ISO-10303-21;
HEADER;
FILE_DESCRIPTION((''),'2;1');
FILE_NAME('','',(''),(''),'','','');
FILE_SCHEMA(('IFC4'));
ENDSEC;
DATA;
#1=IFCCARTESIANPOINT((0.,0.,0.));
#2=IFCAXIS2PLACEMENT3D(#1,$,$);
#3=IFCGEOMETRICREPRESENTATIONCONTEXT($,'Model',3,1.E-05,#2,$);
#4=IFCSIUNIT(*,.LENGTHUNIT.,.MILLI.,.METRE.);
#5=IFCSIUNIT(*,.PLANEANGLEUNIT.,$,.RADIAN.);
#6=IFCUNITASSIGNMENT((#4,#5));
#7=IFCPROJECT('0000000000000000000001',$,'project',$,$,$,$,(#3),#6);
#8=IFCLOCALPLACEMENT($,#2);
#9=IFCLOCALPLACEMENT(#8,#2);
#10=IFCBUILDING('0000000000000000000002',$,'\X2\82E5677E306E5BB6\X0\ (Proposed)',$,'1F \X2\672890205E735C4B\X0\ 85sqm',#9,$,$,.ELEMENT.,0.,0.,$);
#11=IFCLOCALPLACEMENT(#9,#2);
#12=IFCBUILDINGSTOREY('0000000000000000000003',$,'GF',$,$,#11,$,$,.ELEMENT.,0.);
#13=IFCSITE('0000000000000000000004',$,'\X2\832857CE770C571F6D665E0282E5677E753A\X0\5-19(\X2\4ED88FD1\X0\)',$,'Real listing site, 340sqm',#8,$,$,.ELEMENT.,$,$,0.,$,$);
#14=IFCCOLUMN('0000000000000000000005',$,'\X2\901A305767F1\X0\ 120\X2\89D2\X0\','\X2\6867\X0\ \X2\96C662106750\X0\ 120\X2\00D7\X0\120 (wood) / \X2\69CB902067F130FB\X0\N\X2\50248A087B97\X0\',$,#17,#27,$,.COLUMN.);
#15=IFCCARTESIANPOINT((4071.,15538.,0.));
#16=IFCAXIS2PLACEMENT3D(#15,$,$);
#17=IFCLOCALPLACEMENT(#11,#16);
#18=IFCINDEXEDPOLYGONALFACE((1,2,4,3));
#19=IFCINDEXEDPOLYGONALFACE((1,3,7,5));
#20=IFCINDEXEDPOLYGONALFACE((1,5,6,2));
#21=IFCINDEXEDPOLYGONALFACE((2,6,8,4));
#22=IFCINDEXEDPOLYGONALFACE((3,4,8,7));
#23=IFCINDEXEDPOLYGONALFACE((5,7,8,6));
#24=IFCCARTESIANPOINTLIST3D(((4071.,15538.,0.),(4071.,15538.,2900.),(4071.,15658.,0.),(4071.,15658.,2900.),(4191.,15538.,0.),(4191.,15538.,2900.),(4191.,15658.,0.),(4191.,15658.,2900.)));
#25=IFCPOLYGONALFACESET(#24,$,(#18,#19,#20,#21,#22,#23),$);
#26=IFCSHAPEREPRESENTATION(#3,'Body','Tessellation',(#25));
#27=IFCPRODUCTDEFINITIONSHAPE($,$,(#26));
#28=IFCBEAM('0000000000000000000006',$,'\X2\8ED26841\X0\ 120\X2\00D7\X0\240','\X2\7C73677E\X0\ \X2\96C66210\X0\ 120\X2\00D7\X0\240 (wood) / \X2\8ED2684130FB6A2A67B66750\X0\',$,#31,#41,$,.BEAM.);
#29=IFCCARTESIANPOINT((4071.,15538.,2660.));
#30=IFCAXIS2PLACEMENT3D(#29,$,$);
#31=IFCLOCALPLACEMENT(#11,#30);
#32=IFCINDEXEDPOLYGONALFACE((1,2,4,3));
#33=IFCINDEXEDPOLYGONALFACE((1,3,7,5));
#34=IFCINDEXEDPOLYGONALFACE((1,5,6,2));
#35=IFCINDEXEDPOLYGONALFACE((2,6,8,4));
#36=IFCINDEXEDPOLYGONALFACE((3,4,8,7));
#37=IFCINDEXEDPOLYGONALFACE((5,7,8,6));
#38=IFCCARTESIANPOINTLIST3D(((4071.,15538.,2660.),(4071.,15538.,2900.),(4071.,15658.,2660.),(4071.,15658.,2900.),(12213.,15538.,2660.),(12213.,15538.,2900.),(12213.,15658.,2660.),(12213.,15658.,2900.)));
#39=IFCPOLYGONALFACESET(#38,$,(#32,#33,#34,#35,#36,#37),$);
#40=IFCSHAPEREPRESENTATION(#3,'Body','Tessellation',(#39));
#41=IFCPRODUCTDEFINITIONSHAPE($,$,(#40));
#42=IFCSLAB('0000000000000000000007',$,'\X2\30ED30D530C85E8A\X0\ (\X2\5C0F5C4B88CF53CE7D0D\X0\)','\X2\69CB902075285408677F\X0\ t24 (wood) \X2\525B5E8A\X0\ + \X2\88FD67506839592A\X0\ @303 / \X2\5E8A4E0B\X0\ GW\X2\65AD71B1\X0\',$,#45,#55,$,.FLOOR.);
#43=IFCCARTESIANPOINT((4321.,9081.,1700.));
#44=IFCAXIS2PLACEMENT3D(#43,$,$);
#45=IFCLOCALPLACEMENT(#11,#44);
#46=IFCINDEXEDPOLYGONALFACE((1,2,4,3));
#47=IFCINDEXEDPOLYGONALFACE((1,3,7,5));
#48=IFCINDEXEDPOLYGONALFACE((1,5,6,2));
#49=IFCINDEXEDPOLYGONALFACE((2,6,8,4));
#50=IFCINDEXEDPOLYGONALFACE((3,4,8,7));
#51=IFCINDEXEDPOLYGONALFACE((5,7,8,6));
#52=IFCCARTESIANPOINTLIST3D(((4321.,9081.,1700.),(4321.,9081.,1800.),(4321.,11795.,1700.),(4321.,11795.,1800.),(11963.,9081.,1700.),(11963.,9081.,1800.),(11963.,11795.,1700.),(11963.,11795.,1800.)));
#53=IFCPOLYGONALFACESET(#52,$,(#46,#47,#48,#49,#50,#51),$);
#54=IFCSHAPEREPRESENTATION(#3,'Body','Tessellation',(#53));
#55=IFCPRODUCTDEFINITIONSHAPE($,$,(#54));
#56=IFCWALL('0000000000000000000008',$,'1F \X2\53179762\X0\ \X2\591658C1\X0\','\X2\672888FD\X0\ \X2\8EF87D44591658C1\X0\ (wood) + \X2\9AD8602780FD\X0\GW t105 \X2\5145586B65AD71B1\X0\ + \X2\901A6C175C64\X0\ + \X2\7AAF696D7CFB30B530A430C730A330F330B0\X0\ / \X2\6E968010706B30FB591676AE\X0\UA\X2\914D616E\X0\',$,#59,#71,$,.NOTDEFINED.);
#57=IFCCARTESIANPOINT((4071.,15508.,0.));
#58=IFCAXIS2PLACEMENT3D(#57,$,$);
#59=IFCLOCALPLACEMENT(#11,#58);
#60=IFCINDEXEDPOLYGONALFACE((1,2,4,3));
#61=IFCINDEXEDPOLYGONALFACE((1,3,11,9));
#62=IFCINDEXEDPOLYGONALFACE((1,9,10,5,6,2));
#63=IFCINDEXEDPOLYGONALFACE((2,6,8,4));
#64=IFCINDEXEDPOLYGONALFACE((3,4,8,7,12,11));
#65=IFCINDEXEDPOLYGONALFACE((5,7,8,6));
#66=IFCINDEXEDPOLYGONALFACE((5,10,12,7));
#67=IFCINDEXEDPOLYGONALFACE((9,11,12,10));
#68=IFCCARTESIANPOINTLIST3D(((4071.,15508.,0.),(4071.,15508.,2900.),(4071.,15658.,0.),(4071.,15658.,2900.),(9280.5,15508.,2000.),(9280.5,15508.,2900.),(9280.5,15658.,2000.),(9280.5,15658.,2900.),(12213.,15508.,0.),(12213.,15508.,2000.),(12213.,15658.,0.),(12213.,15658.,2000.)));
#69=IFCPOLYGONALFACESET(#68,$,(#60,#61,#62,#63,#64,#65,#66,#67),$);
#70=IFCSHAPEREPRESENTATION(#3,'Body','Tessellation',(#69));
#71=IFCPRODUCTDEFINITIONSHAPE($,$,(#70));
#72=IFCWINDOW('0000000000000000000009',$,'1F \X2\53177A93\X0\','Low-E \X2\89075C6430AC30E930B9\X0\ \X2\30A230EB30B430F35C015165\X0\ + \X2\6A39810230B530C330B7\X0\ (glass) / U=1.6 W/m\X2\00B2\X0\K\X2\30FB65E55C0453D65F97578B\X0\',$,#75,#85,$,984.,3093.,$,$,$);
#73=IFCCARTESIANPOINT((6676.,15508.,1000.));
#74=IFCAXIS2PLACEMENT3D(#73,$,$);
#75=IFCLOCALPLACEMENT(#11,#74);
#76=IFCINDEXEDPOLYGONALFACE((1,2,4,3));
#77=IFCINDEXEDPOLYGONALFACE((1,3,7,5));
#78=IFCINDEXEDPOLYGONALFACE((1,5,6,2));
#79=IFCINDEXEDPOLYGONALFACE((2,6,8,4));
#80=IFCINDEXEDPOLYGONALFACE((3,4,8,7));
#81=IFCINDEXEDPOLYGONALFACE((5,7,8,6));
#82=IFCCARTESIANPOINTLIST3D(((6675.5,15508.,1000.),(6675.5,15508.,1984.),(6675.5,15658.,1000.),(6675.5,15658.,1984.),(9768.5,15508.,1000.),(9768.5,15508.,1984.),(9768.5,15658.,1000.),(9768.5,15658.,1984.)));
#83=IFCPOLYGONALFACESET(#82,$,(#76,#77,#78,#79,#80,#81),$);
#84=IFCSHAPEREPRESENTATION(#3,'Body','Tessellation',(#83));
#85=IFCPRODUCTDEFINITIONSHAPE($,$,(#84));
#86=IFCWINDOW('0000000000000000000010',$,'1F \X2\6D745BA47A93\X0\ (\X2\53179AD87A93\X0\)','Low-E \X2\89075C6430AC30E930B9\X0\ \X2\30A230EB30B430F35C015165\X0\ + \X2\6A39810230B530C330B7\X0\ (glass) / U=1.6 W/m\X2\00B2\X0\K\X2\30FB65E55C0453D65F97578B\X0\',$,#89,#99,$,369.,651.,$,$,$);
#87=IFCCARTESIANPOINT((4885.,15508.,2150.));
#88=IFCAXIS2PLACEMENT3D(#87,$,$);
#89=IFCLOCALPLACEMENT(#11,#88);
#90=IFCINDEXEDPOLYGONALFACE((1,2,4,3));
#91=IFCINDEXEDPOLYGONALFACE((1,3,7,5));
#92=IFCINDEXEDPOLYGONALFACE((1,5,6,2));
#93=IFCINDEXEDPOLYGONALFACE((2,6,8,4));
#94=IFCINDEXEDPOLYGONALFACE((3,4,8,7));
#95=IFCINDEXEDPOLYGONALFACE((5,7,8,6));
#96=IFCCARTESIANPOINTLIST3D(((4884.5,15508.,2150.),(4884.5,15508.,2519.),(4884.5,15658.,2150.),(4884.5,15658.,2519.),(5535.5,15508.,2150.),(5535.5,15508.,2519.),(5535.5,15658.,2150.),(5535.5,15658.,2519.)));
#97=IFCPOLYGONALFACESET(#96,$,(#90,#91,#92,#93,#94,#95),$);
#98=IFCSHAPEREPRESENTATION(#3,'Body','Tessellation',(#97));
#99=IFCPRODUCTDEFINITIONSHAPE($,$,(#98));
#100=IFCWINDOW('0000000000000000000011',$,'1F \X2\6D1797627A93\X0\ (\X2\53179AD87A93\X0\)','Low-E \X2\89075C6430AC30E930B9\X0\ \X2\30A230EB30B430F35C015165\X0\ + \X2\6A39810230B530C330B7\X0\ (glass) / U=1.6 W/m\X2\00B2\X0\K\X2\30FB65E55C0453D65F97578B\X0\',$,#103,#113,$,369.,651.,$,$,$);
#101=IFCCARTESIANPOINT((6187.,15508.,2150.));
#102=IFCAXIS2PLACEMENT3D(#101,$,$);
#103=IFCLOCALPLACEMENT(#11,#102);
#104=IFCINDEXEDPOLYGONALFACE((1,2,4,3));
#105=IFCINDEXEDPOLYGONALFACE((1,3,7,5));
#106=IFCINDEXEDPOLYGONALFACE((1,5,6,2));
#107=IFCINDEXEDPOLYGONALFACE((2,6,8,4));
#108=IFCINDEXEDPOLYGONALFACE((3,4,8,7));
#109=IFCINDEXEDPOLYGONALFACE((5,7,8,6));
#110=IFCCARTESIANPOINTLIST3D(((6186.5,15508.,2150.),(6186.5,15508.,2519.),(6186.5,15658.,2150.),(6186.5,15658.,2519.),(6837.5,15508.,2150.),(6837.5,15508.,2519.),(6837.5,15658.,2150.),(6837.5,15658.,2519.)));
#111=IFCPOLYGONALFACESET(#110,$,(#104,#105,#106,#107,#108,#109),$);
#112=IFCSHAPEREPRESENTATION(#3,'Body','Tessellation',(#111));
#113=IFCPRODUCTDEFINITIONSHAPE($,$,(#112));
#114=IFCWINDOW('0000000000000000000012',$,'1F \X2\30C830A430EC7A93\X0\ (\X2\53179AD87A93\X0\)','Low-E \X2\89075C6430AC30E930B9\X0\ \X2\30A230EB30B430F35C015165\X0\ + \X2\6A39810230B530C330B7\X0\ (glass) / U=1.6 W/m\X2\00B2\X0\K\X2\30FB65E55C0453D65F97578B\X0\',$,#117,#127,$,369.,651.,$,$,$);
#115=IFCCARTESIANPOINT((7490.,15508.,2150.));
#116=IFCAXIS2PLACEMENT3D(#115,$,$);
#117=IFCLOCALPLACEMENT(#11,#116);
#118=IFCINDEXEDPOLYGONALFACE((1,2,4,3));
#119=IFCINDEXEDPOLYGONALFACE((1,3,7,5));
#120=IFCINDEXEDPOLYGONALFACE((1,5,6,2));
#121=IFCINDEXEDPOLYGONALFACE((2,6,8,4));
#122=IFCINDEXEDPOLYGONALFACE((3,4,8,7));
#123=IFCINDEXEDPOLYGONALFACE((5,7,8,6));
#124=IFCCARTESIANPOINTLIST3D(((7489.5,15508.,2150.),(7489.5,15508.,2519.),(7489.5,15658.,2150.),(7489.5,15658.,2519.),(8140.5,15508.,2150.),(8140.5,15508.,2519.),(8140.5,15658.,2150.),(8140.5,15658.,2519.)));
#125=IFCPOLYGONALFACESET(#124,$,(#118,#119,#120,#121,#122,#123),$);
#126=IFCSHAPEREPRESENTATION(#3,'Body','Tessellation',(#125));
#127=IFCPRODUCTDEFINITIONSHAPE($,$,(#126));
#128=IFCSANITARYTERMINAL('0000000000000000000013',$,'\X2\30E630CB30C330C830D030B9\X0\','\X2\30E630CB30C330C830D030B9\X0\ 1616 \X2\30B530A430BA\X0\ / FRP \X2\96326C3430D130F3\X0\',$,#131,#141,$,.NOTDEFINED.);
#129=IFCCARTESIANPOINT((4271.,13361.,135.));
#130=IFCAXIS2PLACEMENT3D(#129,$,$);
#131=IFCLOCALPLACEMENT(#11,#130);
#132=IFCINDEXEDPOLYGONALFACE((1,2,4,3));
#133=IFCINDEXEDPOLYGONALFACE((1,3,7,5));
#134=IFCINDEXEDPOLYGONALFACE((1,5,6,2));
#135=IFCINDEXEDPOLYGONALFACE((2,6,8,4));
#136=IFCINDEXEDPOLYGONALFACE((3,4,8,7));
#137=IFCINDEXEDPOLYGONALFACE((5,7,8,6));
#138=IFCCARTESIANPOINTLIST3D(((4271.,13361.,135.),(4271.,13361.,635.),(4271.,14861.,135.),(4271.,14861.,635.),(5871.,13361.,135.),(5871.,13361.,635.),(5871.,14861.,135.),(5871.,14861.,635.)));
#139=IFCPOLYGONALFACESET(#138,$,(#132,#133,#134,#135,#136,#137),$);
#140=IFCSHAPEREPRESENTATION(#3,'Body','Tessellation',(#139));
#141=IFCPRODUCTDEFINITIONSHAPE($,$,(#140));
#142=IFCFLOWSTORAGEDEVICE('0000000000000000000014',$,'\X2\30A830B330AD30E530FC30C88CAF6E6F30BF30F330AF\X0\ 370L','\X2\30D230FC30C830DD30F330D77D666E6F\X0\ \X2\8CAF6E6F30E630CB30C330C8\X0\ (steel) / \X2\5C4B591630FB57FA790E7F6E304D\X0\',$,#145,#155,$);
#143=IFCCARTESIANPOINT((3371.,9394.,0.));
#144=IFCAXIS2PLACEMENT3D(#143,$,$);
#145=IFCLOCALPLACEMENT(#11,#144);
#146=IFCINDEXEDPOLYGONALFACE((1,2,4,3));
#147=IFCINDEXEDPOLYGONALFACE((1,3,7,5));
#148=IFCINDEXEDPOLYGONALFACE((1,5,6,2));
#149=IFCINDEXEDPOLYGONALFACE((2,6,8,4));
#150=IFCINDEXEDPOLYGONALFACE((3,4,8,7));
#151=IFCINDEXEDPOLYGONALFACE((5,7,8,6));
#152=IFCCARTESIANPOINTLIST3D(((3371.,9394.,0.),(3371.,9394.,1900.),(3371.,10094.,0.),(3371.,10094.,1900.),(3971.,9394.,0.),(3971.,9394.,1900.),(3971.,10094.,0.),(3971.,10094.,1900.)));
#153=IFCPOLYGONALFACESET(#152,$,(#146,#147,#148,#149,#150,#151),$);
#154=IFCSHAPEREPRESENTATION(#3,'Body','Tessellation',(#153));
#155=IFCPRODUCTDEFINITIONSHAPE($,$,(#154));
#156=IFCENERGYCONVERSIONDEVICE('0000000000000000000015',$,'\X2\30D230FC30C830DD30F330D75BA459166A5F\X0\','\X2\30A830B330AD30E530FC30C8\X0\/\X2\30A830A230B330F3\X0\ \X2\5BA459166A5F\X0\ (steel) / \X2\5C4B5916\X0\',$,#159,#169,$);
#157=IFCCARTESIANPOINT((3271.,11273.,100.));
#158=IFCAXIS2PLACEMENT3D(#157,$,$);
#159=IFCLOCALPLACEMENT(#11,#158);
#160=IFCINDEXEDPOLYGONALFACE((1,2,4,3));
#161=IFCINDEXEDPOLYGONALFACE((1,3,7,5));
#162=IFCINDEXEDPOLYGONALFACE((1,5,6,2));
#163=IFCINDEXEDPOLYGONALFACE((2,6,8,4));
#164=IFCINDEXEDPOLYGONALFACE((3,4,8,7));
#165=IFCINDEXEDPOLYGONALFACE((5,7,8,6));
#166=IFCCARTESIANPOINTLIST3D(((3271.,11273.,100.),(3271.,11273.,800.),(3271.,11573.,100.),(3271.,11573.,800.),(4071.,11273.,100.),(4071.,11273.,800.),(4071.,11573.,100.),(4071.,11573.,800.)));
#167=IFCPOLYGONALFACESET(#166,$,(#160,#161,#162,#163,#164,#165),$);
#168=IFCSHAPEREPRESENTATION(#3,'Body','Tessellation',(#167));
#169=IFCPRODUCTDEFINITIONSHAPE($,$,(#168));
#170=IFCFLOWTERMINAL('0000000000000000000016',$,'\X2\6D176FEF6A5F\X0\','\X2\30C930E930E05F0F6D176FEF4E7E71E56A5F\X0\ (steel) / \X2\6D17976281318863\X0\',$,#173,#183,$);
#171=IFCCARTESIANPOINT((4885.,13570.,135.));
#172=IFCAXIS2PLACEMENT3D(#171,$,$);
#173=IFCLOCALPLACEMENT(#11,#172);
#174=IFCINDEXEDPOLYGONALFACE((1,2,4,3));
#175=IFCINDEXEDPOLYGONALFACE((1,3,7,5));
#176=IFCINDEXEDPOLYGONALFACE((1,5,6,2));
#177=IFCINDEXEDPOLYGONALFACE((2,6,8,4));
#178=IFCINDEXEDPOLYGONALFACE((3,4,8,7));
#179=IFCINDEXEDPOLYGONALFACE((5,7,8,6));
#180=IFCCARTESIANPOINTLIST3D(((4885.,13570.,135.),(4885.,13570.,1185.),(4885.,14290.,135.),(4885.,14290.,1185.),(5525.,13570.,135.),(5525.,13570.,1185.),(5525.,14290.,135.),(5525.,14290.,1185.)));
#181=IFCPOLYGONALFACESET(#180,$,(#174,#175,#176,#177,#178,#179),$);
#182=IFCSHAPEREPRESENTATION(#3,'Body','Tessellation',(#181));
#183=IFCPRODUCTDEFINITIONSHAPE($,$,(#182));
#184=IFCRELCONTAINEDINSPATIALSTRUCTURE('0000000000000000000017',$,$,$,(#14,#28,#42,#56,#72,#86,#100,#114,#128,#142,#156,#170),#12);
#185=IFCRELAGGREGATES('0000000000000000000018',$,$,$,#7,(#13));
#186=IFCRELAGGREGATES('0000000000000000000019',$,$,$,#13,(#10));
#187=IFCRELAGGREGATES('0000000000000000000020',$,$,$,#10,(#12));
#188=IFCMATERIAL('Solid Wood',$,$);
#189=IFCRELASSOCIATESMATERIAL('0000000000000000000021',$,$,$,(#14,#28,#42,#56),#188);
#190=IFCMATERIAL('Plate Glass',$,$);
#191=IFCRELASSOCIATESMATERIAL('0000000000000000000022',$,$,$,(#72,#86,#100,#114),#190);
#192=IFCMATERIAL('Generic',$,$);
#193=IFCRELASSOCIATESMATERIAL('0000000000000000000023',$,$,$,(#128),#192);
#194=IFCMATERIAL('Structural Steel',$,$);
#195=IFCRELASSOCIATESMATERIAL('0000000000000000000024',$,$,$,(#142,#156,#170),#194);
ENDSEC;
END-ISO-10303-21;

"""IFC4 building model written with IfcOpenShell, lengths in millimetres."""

from ifc_helpers import new_model, si_unit, frame, frame_2d, origin, place, context, project, spatial, rectangle, extrude, material, element, fill, save


model = new_model("IFC4")

# Units and contexts
model_context = context("Model", 3, precision=1e-05, world=origin())
ifc_project = project(units=[si_unit("LENGTHUNIT", "METRE", prefix="MILLI"), si_unit("PLANEANGLEUNIT", "RADIAN")], contexts=[model_context])

# Site, building, storey
site_placement = place(None, origin())
site = spatial("IfcSite", under=ifc_project, at=site_placement, Name="茨城県土浦市若松町5-19(付近)", ObjectType="Real listing site, 340sqm", CompositionType="ELEMENT", RefElevation=0.0)
building_placement = place(site_placement, origin())
building = spatial("IfcBuilding", under=site, at=building_placement, Name="若松の家 (Proposed)", ObjectType="1F 木造平屋 85sqm", CompositionType="ELEMENT", ElevationOfRefHeight=0.0, ElevationOfTerrain=0.0)
storey_placement = place(building_placement, origin())
storey = spatial("IfcBuildingStorey", under=building, at=storey_placement, Name="GF", CompositionType="ELEMENT", Elevation=0.0)

# Column
ifc_material_1 = material(Name="Solid Wood")
column_1_placement = place(storey_placement, frame((4071.0, 15538.0, 0.0)))
element("IfcColumn", 1, at=column_1_placement, inside=storey, material=ifc_material_1, Name="通し柱 120角", Description="桧 集成材 120×120 (wood) / 構造柱・N値計算", PredefinedType="COLUMN", context=model_context, shape_type="SweptSolid", body=[
    extrude(rectangle(XDim=120.0, YDim=120.0, at=frame_2d((60.0, 60.0))), frame((4071.0, 15538.0, 0.0)), (0.0, 0.0, 1.0), 2900.0),
])

# Beam
beam_1_placement = place(storey_placement, frame((4071.0, 15538.0, 2660.0)))
element("IfcBeam", 2, at=beam_1_placement, inside=storey, material=ifc_material_1, Name="軒桁 120×240", Description="米松 集成 120×240 (wood) / 軒桁・横架材", PredefinedType="BEAM", context=model_context, shape_type="SweptSolid", body=[
    extrude(rectangle(XDim=8142.0, YDim=120.0, at=frame_2d((4071.0, 60.0))), frame((4071.0, 15538.0, 2660.0)), (0.0, 0.0, 1.0), 240.0),
])

# Slab
slab_placement = place(storey_placement, frame((4321.0, 9081.0, 1700.0)))
element("IfcSlab", 3, at=slab_placement, inside=storey, material=ifc_material_1, Name="ロフト床 (小屋裏収納)", Description="構造用合板 t24 (wood) 剛床 + 製材根太 @303 / 床下 GW断熱", PredefinedType="FLOOR", context=model_context, shape_type="SweptSolid", body=[
    extrude(rectangle(XDim=7642.0, YDim=2714.0, at=frame_2d((3821.0, 1357.0))), frame((4321.0, 9081.0, 1700.0)), (0.0, 0.0, 1.0), 100.0),
])

# Wall, openings, windows
wall_1_placement = place(storey_placement, frame((4071.0, 15508.0, 0.0)))
wall_1 = element("IfcWall", 4, at=wall_1_placement, inside=storey, material=ifc_material_1, Name="1F 北面 外壁", Description="木製 軸組外壁 (wood) + 高性能GW t105 充填断熱 + 通気層 + 窯業系サイディング / 準耐火・外皮UA配慮", PredefinedType="NOTDEFINED", context=model_context, shape_type="SweptSolid", body=[
    extrude(rectangle(XDim=8142.0, YDim=150.0, at=frame_2d((4071.0, 75.0))), frame((4071.0, 15508.0, 0.0)), (0.0, 0.0, 1.0), 2900.0),
])
opening_1_placement = place(storey_placement, frame((6676.0, 15508.0, 1000.0)))
opening_1 = element("IfcOpeningElement", 5, at=opening_1_placement, cuts=wall_1, PredefinedType="NOTDEFINED", context=model_context, shape_type="SweptSolid", body=[
    extrude(rectangle(XDim=3093.0, YDim=150.0, at=frame_2d((1546.0, 75.0))), frame((6676.0, 15508.0, 1000.0)), (0.0, 0.0, 1.0), 984.0),
])
opening_2_placement = place(storey_placement, frame((4885.0, 15508.0, 2150.0)))
opening_2 = element("IfcOpeningElement", 6, at=opening_2_placement, cuts=wall_1, PredefinedType="NOTDEFINED", context=model_context, shape_type="SweptSolid", body=[
    extrude(rectangle(XDim=651.0, YDim=150.0, at=frame_2d((325.0, 75.0))), frame((4885.0, 15508.0, 2150.0)), (0.0, 0.0, 1.0), 369.0),
])
opening_3_placement = place(storey_placement, frame((6187.0, 15508.0, 2150.0)))
opening_3 = element("IfcOpeningElement", 7, at=opening_3_placement, cuts=wall_1, PredefinedType="NOTDEFINED", context=model_context, shape_type="SweptSolid", body=[
    extrude(rectangle(XDim=651.0, YDim=150.0, at=frame_2d((325.0, 75.0))), frame((6187.0, 15508.0, 2150.0)), (0.0, 0.0, 1.0), 369.0),
])
opening_4_placement = place(storey_placement, frame((7490.0, 15508.0, 2150.0)))
opening_4 = element("IfcOpeningElement", 8, at=opening_4_placement, cuts=wall_1, PredefinedType="NOTDEFINED", context=model_context, shape_type="SweptSolid", body=[
    extrude(rectangle(XDim=651.0, YDim=150.0, at=frame_2d((325.0, 75.0))), frame((7490.0, 15508.0, 2150.0)), (0.0, 0.0, 1.0), 369.0),
])
ifc_material_2 = material(Name="Plate Glass")
window_1_placement = place(storey_placement, frame((6676.0, 15508.0, 1000.0)))
window_1 = element("IfcWindow", 9, at=window_1_placement, inside=storey, material=ifc_material_2, Name="1F 北窓", Description="Low-E 複層ガラス アルゴン封入 + 樹脂サッシ (glass) / U=1.6 W/m²K・日射取得型", OverallHeight=984.0, OverallWidth=3093.0, context=model_context, shape_type="SweptSolid", body=[
    extrude(rectangle(XDim=3093.0, YDim=150.0, at=frame_2d((1546.0, 75.0))), frame((6676.0, 15508.0, 1000.0)), (0.0, 0.0, 1.0), 984.0),
])
fill(opening_1, window_1)
window_2_placement = place(storey_placement, frame((4885.0, 15508.0, 2150.0)))
window_2 = element("IfcWindow", 10, at=window_2_placement, inside=storey, material=ifc_material_2, Name="1F 浴室窓 (北高窓)", Description="Low-E 複層ガラス アルゴン封入 + 樹脂サッシ (glass) / U=1.6 W/m²K・日射取得型", OverallHeight=369.0, OverallWidth=651.0, context=model_context, shape_type="SweptSolid", body=[
    extrude(rectangle(XDim=651.0, YDim=150.0, at=frame_2d((325.0, 75.0))), frame((4885.0, 15508.0, 2150.0)), (0.0, 0.0, 1.0), 369.0),
])
fill(opening_2, window_2)
window_3_placement = place(storey_placement, frame((6187.0, 15508.0, 2150.0)))
window_3 = element("IfcWindow", 11, at=window_3_placement, inside=storey, material=ifc_material_2, Name="1F 洗面窓 (北高窓)", Description="Low-E 複層ガラス アルゴン封入 + 樹脂サッシ (glass) / U=1.6 W/m²K・日射取得型", OverallHeight=369.0, OverallWidth=651.0, context=model_context, shape_type="SweptSolid", body=[
    extrude(rectangle(XDim=651.0, YDim=150.0, at=frame_2d((325.0, 75.0))), frame((6187.0, 15508.0, 2150.0)), (0.0, 0.0, 1.0), 369.0),
])
fill(opening_3, window_3)
window_4_placement = place(storey_placement, frame((7490.0, 15508.0, 2150.0)))
window_4 = element("IfcWindow", 12, at=window_4_placement, inside=storey, material=ifc_material_2, Name="1F トイレ窓 (北高窓)", Description="Low-E 複層ガラス アルゴン封入 + 樹脂サッシ (glass) / U=1.6 W/m²K・日射取得型", OverallHeight=369.0, OverallWidth=651.0, context=model_context, shape_type="SweptSolid", body=[
    extrude(rectangle(XDim=651.0, YDim=150.0, at=frame_2d((325.0, 75.0))), frame((7490.0, 15508.0, 2150.0)), (0.0, 0.0, 1.0), 369.0),
])
fill(opening_4, window_4)

# Sanitary terminal
ifc_material_3 = material(Name="Generic")
sanitary_terminal_placement = place(storey_placement, frame((4271.0, 13361.0, 135.0)))
element("IfcSanitaryTerminal", 13, at=sanitary_terminal_placement, inside=storey, material=ifc_material_3, Name="ユニットバス", Description="ユニットバス 1616 サイズ / FRP 防水パン", PredefinedType="NOTDEFINED", context=model_context, shape_type="SweptSolid", body=[
    extrude(rectangle(XDim=1600.0, YDim=1500.0, at=frame_2d((800.0, 750.0))), frame((4271.0, 13361.0, 135.0)), (0.0, 0.0, 1.0), 500.0),
])

# Flow storage device
ifc_material_4 = material(Name="Structural Steel")
flow_storage_device_placement = place(storey_placement, frame((3371.0, 9394.0, 0.0)))
element("IfcFlowStorageDevice", 14, at=flow_storage_device_placement, inside=storey, material=ifc_material_4, Name="エコキュート貯湯タンク 370L", Description="ヒートポンプ給湯 貯湯ユニット (steel) / 屋外・基礎置き", context=model_context, shape_type="SweptSolid", body=[
    extrude(rectangle(XDim=600.0, YDim=700.0, at=frame_2d((300.0, 350.0))), frame((3371.0, 9394.0, 0.0)), (0.0, 0.0, 1.0), 1900.0),
])

# Energy conversion device
energy_conversion_device_placement = place(storey_placement, frame((3271.0, 11273.0, 100.0)))
element("IfcEnergyConversionDevice", 15, at=energy_conversion_device_placement, inside=storey, material=ifc_material_4, Name="ヒートポンプ室外機", Description="エコキュート/エアコン 室外機 (steel) / 屋外", context=model_context, shape_type="SweptSolid", body=[
    extrude(rectangle(XDim=800.0, YDim=300.0, at=frame_2d((400.0, 150.0))), frame((3271.0, 11273.0, 100.0)), (0.0, 0.0, 1.0), 700.0),
])

# Flow terminal
flow_terminal_placement = place(storey_placement, frame((4885.0, 13570.0, 135.0)))
element("IfcFlowTerminal", 16, at=flow_terminal_placement, inside=storey, material=ifc_material_4, Name="洗濯機", Description="ドラム式洗濯乾燥機 (steel) / 洗面脱衣", context=model_context, shape_type="SweptSolid", body=[
    extrude(rectangle(XDim=640.0, YDim=720.0, at=frame_2d((320.0, 360.0))), frame((4885.0, 13570.0, 135.0)), (0.0, 0.0, 1.0), 1050.0),
])

save(model, "model.ifc")
